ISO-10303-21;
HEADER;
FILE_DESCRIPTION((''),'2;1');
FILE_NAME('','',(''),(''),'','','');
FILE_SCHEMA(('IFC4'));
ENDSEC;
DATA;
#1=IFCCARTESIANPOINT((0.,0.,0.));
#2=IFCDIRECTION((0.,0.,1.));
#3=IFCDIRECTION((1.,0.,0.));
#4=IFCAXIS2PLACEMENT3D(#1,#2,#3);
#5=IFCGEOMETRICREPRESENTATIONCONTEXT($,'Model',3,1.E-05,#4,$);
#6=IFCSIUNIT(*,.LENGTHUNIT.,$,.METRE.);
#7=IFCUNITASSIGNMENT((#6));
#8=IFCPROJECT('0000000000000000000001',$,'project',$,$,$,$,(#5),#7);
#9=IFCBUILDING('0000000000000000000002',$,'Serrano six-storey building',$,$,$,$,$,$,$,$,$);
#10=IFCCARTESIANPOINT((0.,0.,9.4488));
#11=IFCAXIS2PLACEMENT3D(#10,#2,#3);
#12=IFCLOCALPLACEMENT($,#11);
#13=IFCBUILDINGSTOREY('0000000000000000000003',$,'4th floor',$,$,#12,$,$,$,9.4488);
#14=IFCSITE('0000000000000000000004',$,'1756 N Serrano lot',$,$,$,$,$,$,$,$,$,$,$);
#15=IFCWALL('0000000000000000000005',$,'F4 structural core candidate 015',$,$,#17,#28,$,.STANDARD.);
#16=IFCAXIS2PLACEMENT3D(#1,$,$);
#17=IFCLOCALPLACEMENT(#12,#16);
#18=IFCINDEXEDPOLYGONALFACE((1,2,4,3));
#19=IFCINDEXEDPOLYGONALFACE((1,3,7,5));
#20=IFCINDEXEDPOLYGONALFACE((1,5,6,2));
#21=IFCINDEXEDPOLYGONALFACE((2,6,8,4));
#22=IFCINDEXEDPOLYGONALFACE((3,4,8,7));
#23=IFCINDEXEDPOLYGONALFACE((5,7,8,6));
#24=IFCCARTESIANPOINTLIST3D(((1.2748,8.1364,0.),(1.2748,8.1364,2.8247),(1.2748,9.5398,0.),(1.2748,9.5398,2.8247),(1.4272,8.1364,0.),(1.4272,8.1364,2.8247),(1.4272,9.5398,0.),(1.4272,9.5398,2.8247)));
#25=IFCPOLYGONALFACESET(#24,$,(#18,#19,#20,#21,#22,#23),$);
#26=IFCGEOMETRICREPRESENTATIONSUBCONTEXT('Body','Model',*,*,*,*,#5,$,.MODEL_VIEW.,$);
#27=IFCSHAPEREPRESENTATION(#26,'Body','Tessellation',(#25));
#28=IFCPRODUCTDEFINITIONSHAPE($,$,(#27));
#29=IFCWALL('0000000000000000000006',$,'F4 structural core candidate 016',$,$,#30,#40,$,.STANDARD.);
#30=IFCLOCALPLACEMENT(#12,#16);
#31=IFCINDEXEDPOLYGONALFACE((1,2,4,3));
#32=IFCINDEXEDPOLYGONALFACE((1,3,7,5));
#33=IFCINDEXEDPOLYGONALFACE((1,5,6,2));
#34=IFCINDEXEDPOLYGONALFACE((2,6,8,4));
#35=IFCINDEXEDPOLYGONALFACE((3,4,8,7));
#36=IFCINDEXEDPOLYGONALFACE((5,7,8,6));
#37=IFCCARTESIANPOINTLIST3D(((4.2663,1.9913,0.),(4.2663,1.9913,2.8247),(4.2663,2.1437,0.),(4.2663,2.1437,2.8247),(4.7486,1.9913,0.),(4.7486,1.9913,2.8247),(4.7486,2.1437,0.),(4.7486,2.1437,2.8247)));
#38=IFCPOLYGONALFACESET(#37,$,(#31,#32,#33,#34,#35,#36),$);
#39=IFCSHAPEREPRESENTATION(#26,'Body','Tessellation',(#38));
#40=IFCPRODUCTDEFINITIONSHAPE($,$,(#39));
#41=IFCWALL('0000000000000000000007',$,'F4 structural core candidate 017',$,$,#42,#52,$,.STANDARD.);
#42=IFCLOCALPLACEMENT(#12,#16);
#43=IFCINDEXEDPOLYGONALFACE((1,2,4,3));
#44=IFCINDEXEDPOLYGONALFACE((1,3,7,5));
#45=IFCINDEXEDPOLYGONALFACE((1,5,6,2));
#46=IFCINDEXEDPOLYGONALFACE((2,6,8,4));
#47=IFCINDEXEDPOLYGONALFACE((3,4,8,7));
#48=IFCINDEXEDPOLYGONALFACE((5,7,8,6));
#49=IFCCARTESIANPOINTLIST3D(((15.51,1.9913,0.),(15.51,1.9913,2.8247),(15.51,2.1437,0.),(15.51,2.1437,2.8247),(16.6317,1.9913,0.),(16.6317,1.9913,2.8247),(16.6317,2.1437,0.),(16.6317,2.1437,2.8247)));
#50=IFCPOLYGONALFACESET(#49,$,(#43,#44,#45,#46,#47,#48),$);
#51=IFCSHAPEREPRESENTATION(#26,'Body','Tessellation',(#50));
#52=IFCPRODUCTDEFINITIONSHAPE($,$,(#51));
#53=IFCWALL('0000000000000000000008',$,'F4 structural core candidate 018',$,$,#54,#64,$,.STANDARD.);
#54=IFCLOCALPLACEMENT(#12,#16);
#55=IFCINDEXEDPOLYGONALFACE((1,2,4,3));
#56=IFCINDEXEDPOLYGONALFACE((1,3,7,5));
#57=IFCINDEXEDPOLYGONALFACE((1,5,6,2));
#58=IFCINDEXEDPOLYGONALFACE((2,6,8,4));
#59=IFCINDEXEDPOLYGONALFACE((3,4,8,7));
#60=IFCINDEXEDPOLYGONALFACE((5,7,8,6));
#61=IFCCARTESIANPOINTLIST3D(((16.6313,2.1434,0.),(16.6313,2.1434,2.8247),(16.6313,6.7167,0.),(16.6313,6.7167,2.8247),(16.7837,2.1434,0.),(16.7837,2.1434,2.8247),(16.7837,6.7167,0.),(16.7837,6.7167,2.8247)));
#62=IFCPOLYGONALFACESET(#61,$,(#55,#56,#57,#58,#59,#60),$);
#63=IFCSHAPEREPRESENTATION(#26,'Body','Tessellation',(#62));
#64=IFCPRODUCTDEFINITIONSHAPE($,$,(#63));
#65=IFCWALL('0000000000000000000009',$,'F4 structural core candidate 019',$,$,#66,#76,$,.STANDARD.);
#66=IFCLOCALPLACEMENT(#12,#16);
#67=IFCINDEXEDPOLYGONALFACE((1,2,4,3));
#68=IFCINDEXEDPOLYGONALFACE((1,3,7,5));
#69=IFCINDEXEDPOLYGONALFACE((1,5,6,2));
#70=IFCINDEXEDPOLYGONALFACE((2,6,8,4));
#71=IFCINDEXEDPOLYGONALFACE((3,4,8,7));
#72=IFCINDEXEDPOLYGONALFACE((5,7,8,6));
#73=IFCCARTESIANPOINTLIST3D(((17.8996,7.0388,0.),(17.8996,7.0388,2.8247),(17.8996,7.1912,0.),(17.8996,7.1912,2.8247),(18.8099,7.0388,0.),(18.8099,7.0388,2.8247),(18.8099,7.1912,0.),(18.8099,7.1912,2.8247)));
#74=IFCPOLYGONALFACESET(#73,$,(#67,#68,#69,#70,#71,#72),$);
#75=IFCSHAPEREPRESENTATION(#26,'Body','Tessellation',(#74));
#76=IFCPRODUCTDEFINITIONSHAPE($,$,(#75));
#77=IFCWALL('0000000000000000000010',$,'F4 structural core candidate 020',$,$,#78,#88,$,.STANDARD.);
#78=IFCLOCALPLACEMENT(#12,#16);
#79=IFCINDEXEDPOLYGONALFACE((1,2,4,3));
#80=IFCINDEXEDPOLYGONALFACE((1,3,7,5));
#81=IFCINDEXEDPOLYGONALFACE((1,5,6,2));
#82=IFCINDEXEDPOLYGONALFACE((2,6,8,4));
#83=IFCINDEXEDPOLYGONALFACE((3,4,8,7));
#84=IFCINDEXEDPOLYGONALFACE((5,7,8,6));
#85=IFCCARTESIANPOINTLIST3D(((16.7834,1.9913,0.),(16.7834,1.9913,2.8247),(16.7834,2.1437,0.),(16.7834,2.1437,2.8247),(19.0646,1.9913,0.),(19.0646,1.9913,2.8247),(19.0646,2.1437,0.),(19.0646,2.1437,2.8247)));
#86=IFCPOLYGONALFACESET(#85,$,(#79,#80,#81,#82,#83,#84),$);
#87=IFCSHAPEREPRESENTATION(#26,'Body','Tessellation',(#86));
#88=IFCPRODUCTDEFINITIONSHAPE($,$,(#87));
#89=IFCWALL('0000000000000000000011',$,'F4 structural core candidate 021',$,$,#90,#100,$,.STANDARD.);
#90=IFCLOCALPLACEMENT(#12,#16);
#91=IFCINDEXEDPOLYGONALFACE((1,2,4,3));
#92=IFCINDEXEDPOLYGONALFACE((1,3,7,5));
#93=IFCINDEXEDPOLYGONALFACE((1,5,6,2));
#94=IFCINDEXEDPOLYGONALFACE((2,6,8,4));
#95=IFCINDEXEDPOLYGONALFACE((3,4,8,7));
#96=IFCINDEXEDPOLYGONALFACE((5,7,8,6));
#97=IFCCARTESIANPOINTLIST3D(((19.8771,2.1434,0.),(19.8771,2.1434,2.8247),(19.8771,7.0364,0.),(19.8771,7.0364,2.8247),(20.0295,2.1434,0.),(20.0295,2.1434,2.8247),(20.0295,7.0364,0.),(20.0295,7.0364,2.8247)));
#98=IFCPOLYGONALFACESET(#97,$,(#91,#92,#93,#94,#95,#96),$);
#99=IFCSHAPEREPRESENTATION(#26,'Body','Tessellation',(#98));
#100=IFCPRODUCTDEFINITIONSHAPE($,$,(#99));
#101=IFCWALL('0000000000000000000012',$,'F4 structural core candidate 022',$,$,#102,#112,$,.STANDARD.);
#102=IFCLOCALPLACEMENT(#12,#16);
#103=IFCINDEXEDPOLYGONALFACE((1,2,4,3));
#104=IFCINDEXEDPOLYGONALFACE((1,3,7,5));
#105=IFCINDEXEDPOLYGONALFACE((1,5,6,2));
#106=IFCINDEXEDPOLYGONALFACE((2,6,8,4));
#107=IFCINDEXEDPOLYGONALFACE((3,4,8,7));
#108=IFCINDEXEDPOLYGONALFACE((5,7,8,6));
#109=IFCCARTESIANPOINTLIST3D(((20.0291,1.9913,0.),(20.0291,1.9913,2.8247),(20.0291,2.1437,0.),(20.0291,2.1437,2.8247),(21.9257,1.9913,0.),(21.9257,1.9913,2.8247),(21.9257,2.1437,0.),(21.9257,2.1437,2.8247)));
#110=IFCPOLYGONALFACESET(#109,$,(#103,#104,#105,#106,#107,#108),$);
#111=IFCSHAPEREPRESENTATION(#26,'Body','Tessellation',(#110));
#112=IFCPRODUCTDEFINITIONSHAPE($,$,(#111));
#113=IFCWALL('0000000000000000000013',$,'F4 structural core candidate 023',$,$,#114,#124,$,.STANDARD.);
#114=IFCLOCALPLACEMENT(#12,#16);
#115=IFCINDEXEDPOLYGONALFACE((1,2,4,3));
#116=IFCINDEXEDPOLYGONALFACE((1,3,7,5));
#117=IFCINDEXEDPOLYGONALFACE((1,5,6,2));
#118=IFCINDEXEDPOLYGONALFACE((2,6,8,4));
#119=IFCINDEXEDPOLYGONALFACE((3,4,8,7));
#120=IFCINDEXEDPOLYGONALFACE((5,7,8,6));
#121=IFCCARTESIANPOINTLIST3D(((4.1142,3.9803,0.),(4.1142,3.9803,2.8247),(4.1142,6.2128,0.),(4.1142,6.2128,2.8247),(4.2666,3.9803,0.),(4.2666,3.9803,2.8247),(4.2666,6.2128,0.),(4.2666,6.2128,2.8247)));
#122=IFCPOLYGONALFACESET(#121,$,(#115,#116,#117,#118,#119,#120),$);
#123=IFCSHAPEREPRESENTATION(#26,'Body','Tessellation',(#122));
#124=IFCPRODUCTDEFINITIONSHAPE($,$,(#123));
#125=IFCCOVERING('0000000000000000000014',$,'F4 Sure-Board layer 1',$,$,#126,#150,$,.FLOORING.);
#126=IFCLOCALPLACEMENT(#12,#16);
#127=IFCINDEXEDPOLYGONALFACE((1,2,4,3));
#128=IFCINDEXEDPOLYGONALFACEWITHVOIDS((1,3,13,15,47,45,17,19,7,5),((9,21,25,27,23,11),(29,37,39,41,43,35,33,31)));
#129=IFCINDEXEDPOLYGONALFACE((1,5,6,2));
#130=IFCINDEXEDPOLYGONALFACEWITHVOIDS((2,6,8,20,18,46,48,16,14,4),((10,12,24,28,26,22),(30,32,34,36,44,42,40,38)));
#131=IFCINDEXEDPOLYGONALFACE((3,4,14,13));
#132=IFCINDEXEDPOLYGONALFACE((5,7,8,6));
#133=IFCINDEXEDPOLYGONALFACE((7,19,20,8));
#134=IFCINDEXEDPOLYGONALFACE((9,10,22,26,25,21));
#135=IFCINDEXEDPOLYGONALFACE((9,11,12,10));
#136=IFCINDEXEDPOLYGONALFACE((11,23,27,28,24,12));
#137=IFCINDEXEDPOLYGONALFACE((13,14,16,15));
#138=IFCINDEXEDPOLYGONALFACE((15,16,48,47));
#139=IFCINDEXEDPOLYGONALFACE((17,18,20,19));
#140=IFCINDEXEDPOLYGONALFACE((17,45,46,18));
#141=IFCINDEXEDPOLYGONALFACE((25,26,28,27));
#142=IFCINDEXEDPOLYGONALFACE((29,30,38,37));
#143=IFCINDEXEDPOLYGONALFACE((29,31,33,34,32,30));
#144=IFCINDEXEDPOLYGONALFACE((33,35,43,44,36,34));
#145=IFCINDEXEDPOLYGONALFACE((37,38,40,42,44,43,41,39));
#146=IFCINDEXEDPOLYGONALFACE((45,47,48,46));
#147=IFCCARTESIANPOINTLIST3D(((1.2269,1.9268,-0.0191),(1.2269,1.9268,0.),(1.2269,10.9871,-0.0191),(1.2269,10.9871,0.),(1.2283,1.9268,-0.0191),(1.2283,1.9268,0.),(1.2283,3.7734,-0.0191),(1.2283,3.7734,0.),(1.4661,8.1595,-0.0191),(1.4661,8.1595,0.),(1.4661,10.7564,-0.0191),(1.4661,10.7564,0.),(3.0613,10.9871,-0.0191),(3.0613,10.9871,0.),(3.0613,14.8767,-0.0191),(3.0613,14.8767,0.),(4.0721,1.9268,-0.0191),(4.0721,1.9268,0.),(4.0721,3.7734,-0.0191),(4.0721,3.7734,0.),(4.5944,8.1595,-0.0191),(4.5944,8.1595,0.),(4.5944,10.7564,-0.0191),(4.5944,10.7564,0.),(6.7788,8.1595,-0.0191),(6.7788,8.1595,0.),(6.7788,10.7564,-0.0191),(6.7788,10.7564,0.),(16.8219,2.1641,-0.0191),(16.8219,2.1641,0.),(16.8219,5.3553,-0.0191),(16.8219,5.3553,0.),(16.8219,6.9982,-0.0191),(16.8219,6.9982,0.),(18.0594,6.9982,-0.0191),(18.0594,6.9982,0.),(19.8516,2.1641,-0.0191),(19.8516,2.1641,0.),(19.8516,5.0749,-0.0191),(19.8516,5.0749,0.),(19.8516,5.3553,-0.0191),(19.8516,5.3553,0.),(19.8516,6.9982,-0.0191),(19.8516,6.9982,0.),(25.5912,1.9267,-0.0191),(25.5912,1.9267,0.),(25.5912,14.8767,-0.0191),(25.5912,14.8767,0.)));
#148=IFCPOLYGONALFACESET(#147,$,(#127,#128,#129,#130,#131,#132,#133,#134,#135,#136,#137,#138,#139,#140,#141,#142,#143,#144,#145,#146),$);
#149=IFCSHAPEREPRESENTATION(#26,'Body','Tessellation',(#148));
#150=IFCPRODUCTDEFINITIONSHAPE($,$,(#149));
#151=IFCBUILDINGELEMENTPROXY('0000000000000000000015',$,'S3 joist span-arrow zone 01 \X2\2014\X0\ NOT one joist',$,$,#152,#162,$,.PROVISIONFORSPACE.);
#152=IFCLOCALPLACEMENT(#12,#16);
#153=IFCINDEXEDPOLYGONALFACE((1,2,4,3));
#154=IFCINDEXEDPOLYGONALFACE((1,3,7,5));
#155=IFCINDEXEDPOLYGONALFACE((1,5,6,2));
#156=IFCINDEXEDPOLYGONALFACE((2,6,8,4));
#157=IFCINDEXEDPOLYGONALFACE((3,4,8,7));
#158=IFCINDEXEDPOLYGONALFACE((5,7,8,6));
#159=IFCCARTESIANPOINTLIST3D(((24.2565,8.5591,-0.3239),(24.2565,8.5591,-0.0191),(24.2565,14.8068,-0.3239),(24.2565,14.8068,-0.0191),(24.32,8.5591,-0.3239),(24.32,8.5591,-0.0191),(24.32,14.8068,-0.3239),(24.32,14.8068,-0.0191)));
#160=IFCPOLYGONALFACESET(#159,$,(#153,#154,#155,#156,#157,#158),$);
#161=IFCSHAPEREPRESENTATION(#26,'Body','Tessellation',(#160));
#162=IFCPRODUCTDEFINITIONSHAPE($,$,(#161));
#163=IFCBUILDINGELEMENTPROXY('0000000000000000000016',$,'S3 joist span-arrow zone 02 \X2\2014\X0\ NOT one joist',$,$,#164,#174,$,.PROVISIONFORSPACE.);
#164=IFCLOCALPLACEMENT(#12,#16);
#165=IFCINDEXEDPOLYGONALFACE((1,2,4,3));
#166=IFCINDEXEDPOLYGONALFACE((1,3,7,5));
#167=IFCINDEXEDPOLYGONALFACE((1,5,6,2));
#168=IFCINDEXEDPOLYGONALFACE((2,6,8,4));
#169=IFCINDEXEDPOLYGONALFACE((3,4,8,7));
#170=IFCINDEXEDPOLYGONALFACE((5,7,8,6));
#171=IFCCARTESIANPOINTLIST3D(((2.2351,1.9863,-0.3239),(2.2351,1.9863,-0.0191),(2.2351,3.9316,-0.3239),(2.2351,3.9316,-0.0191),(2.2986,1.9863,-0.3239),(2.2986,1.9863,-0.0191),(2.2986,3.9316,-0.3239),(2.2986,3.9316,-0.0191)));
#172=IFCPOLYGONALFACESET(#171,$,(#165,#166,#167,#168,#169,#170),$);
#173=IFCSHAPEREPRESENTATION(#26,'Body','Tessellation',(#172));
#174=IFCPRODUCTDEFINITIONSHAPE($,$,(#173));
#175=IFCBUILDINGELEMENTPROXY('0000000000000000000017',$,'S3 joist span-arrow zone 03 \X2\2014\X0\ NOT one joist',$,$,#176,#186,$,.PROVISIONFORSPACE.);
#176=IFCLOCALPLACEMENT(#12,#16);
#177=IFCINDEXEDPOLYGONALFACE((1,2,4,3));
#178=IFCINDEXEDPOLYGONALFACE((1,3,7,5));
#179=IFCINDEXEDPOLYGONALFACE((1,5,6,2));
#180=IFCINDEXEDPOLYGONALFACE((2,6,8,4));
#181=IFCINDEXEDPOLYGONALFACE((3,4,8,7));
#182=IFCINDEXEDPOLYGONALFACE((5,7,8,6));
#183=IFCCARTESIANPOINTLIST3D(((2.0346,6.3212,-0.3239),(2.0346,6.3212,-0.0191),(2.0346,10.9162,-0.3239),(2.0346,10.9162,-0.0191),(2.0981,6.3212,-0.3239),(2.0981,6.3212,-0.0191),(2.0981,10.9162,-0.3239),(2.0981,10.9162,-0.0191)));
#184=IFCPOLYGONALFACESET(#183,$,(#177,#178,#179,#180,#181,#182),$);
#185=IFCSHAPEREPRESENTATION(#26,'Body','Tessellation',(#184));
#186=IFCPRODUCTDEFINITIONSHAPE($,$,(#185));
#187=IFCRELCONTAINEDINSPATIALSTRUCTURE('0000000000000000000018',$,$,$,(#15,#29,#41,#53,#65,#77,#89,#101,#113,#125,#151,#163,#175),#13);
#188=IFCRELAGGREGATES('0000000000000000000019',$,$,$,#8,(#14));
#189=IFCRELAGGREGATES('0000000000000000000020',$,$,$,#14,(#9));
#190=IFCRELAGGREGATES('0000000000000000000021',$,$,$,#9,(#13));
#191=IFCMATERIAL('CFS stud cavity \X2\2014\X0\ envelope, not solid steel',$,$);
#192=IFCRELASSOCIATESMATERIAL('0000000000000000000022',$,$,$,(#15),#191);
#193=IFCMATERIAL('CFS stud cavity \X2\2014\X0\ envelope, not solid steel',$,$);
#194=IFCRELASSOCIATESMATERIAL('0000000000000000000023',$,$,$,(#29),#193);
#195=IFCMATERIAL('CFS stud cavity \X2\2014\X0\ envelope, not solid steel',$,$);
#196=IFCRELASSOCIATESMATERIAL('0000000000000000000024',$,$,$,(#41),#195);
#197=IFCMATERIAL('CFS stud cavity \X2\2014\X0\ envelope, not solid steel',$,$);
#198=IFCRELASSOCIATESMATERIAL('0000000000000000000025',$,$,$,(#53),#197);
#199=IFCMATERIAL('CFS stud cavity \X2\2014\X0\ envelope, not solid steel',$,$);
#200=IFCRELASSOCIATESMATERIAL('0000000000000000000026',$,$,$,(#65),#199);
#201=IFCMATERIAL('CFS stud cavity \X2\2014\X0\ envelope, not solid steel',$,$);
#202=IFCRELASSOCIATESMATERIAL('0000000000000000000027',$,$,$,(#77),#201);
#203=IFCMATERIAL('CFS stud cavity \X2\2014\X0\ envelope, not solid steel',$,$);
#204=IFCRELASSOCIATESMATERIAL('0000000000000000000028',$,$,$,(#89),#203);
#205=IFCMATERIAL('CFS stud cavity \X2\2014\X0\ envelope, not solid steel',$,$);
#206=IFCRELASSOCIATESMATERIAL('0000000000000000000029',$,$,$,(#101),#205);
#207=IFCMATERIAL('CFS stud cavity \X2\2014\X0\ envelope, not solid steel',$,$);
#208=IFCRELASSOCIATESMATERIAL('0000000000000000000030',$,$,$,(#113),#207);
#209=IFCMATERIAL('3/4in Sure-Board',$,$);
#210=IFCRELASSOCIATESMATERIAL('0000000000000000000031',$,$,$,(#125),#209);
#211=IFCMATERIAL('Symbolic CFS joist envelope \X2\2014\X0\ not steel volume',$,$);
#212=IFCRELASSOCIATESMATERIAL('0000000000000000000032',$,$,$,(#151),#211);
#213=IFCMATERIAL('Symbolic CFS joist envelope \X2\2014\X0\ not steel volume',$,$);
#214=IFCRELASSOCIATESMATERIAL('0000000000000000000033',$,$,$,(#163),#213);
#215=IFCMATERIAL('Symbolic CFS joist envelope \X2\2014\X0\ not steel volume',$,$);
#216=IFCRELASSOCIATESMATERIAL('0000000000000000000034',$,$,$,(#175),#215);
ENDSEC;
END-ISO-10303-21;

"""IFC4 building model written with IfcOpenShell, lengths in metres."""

from ifc_helpers import new_model, si_unit, frame, origin_with_axes, place, context, subcontext, project, spatial, polyline, outline, extrude, material, element, save


model = new_model("IFC4")

# Units and contexts
model_context = context("Model", 3, precision=1e-05, world=origin_with_axes())
body_context = subcontext(model_context, "Body", "Model", "MODEL_VIEW")
ifc_project = project(units=[si_unit("LENGTHUNIT", "METRE")], contexts=[model_context])

# Site, building, storey
site = spatial("IfcSite", under=ifc_project, Name="1756 N Serrano lot")
building = spatial("IfcBuilding", under=site, Name="Serrano six-storey building")
storey_placement = place(None, frame((0.0, 0.0, 9.4488), z_axis=(0.0, 0.0, 1.0), x_axis=(1.0, 0.0, 0.0)))
storey = spatial("IfcBuildingStorey", under=building, at=storey_placement, Name="4th floor", Elevation=9.4488)

# Walls
ifc_material_1 = material(Name="CFS stud cavity — envelope, not solid steel")
wall_1_placement = place(storey_placement, frame((0.0, 0.0, -9.4488), z_axis=(0.0, 0.0, 1.0), x_axis=(1.0, 0.0, 0.0)))
element("IfcWall", 1, at=wall_1_placement, inside=storey, material=ifc_material_1, Name="F4 structural core candidate 015", PredefinedType="STANDARD", context=body_context, shape_type="SweptSolid", body=[
    extrude(outline(polyline([(1.4272, 8.1364), (1.2748, 8.1364), (1.2748, 9.5398), (1.4272, 9.5398), (1.4272, 8.1364)])), frame((0.0, 0.0, 9.4488)), (0.0, 0.0, 1.0), 2.8247),
])
ifc_material_2 = material(Name="CFS stud cavity — envelope, not solid steel")
wall_2_placement = place(storey_placement, frame((0.0, 0.0, -9.4488), z_axis=(0.0, 0.0, 1.0), x_axis=(1.0, 0.0, 0.0)))
element("IfcWall", 2, at=wall_2_placement, inside=storey, material=ifc_material_2, Name="F4 structural core candidate 016", PredefinedType="STANDARD", context=body_context, shape_type="SweptSolid", body=[
    extrude(outline(polyline([(4.7486, 2.1437), (4.7486, 1.9913), (4.2663, 1.9913), (4.2663, 2.1437), (4.7486, 2.1437)])), frame((0.0, 0.0, 9.4488)), (0.0, 0.0, 1.0), 2.8247),
])
ifc_material_3 = material(Name="CFS stud cavity — envelope, not solid steel")
wall_3_placement = place(storey_placement, frame((0.0, 0.0, -9.4488), z_axis=(0.0, 0.0, 1.0), x_axis=(1.0, 0.0, 0.0)))
element("IfcWall", 3, at=wall_3_placement, inside=storey, material=ifc_material_3, Name="F4 structural core candidate 017", PredefinedType="STANDARD", context=body_context, shape_type="SweptSolid", body=[
    extrude(outline(polyline([(16.6317, 2.1437), (16.6317, 1.9913), (15.51, 1.9913), (15.51, 2.1437), (16.6317, 2.1437)])), frame((0.0, 0.0, 9.4488)), (0.0, 0.0, 1.0), 2.8247),
])
ifc_material_4 = material(Name="CFS stud cavity — envelope, not solid steel")
wall_4_placement = place(storey_placement, frame((0.0, 0.0, -9.4488), z_axis=(0.0, 0.0, 1.0), x_axis=(1.0, 0.0, 0.0)))
element("IfcWall", 4, at=wall_4_placement, inside=storey, material=ifc_material_4, Name="F4 structural core candidate 018", PredefinedType="STANDARD", context=body_context, shape_type="SweptSolid", body=[
    extrude(outline(polyline([(16.7837, 2.1434), (16.6313, 2.1434), (16.6313, 6.7167), (16.7837, 6.7167), (16.7837, 2.1434)])), frame((0.0, 0.0, 9.4488)), (0.0, 0.0, 1.0), 2.8247),
])
ifc_material_5 = material(Name="CFS stud cavity — envelope, not solid steel")
wall_5_placement = place(storey_placement, frame((0.0, 0.0, -9.4488), z_axis=(0.0, 0.0, 1.0), x_axis=(1.0, 0.0, 0.0)))
element("IfcWall", 5, at=wall_5_placement, inside=storey, material=ifc_material_5, Name="F4 structural core candidate 019", PredefinedType="STANDARD", context=body_context, shape_type="SweptSolid", body=[
    extrude(outline(polyline([(18.8099, 7.1912), (18.8099, 7.0388), (17.8996, 7.0388), (17.8996, 7.1912), (18.8099, 7.1912)])), frame((0.0, 0.0, 9.4488)), (0.0, 0.0, 1.0), 2.8247),
])
ifc_material_6 = material(Name="CFS stud cavity — envelope, not solid steel")
wall_6_placement = place(storey_placement, frame((0.0, 0.0, -9.4488), z_axis=(0.0, 0.0, 1.0), x_axis=(1.0, 0.0, 0.0)))
element("IfcWall", 6, at=wall_6_placement, inside=storey, material=ifc_material_6, Name="F4 structural core candidate 020", PredefinedType="STANDARD", context=body_context, shape_type="SweptSolid", body=[
    extrude(outline(polyline([(19.0646, 2.1437), (19.0646, 1.9913), (16.7834, 1.9913), (16.7834, 2.1437), (19.0646, 2.1437)])), frame((0.0, 0.0, 9.4488)), (0.0, 0.0, 1.0), 2.8247),
])
ifc_material_7 = material(Name="CFS stud cavity — envelope, not solid steel")
wall_7_placement = place(storey_placement, frame((0.0, 0.0, -9.4488), z_axis=(0.0, 0.0, 1.0), x_axis=(1.0, 0.0, 0.0)))
element("IfcWall", 7, at=wall_7_placement, inside=storey, material=ifc_material_7, Name="F4 structural core candidate 021", PredefinedType="STANDARD", context=body_context, shape_type="SweptSolid", body=[
    extrude(outline(polyline([(20.0295, 2.1434), (19.8771, 2.1434), (19.8771, 7.0364), (20.0295, 7.0364), (20.0295, 2.1434)])), frame((0.0, 0.0, 9.4488)), (0.0, 0.0, 1.0), 2.8247),
])
ifc_material_8 = material(Name="CFS stud cavity — envelope, not solid steel")
wall_8_placement = place(storey_placement, frame((0.0, 0.0, -9.4488), z_axis=(0.0, 0.0, 1.0), x_axis=(1.0, 0.0, 0.0)))
element("IfcWall", 8, at=wall_8_placement, inside=storey, material=ifc_material_8, Name="F4 structural core candidate 022", PredefinedType="STANDARD", context=body_context, shape_type="SweptSolid", body=[
    extrude(outline(polyline([(21.9257, 2.1437), (21.9257, 1.9913), (20.0291, 1.9913), (20.0291, 2.1437), (21.9257, 2.1437)])), frame((0.0, 0.0, 9.4488)), (0.0, 0.0, 1.0), 2.8247),
])
ifc_material_9 = material(Name="CFS stud cavity — envelope, not solid steel")
wall_9_placement = place(storey_placement, frame((0.0, 0.0, -9.4488), z_axis=(0.0, 0.0, 1.0), x_axis=(1.0, 0.0, 0.0)))
element("IfcWall", 9, at=wall_9_placement, inside=storey, material=ifc_material_9, Name="F4 structural core candidate 023", PredefinedType="STANDARD", context=body_context, shape_type="SweptSolid", body=[
    extrude(outline(polyline([(4.2666, 3.9803), (4.1142, 3.9803), (4.1142, 6.2128), (4.2666, 6.2128), (4.2666, 3.9803)])), frame((0.0, 0.0, 9.4488)), (0.0, 0.0, 1.0), 2.8247),
])

# Covering
ifc_material_10 = material(Name="3/4in Sure-Board")
covering_placement = place(storey_placement, frame((0.0, 0.0, -9.4488), z_axis=(0.0, 0.0, 1.0), x_axis=(1.0, 0.0, 0.0)))
element("IfcCovering", 10, at=covering_placement, inside=storey, material=ifc_material_10, Name="F4 Sure-Board layer 1", PredefinedType="FLOORING", context=body_context, shape_type="SweptSolid", body=[
    extrude(outline(polyline([(3.0613, 14.8767), (25.5912, 14.8767), (25.5912, 1.9267), (4.0721, 1.9268), (4.0721, 3.7734), (1.2283, 3.7734), (1.2283, 1.9268), (1.2269, 1.9268), (1.2269, 10.9871), (3.0613, 10.9871), (3.0613, 14.8767)]), holes=[polyline([(6.7788, 10.7564), (4.5944, 10.7564), (1.4661, 10.7564), (1.4661, 8.1595), (4.5944, 8.1595), (6.7788, 8.1595), (6.7788, 10.7564)]), polyline([(16.8219, 5.3553), (16.8219, 2.1641), (19.8516, 2.1641), (19.8516, 5.0749), (19.8516, 5.3553), (19.8516, 6.9982), (18.0594, 6.9982), (16.8219, 6.9982), (16.8219, 5.3553)])]), frame((0.0, 0.0, 9.4298)), (0.0, 0.0, 1.0), 0.0191),
])

# Building element proxies
ifc_material_11 = material(Name="Symbolic CFS joist envelope — not steel volume")
proxy_1_placement = place(storey_placement, frame((0.0, 0.0, -9.4488), z_axis=(0.0, 0.0, 1.0), x_axis=(1.0, 0.0, 0.0)))
element("IfcBuildingElementProxy", 11, at=proxy_1_placement, inside=storey, material=ifc_material_11, Name="S3 joist span-arrow zone 01 — NOT one joist", PredefinedType="PROVISIONFORSPACE", context=body_context, shape_type="SweptSolid", body=[
    extrude(outline(polyline([(24.2565, 14.8068), (24.32, 14.8068), (24.32, 8.5591), (24.2565, 8.5591), (24.2565, 14.8068)])), frame((0.0, 0.0, 9.125)), (0.0, 0.0, 1.0), 0.3048),
])
ifc_material_12 = material(Name="Symbolic CFS joist envelope — not steel volume")
proxy_2_placement = place(storey_placement, frame((0.0, 0.0, -9.4488), z_axis=(0.0, 0.0, 1.0), x_axis=(1.0, 0.0, 0.0)))
element("IfcBuildingElementProxy", 12, at=proxy_2_placement, inside=storey, material=ifc_material_12, Name="S3 joist span-arrow zone 02 — NOT one joist", PredefinedType="PROVISIONFORSPACE", context=body_context, shape_type="SweptSolid", body=[
    extrude(outline(polyline([(2.2351, 3.9316), (2.2986, 3.9316), (2.2986, 1.9863), (2.2351, 1.9863), (2.2351, 3.9316)])), frame((0.0, 0.0, 9.125)), (0.0, 0.0, 1.0), 0.3048),
])
ifc_material_13 = material(Name="Symbolic CFS joist envelope — not steel volume")
proxy_3_placement = place(storey_placement, frame((0.0, 0.0, -9.4488), z_axis=(0.0, 0.0, 1.0), x_axis=(1.0, 0.0, 0.0)))
element("IfcBuildingElementProxy", 13, at=proxy_3_placement, inside=storey, material=ifc_material_13, Name="S3 joist span-arrow zone 03 — NOT one joist", PredefinedType="PROVISIONFORSPACE", context=body_context, shape_type="SweptSolid", body=[
    extrude(outline(polyline([(2.0346, 10.9162), (2.0981, 10.9162), (2.0981, 6.3212), (2.0346, 6.3212), (2.0346, 10.9162)])), frame((0.0, 0.0, 9.125)), (0.0, 0.0, 1.0), 0.3048),
])

save(model, "model.ifc")
